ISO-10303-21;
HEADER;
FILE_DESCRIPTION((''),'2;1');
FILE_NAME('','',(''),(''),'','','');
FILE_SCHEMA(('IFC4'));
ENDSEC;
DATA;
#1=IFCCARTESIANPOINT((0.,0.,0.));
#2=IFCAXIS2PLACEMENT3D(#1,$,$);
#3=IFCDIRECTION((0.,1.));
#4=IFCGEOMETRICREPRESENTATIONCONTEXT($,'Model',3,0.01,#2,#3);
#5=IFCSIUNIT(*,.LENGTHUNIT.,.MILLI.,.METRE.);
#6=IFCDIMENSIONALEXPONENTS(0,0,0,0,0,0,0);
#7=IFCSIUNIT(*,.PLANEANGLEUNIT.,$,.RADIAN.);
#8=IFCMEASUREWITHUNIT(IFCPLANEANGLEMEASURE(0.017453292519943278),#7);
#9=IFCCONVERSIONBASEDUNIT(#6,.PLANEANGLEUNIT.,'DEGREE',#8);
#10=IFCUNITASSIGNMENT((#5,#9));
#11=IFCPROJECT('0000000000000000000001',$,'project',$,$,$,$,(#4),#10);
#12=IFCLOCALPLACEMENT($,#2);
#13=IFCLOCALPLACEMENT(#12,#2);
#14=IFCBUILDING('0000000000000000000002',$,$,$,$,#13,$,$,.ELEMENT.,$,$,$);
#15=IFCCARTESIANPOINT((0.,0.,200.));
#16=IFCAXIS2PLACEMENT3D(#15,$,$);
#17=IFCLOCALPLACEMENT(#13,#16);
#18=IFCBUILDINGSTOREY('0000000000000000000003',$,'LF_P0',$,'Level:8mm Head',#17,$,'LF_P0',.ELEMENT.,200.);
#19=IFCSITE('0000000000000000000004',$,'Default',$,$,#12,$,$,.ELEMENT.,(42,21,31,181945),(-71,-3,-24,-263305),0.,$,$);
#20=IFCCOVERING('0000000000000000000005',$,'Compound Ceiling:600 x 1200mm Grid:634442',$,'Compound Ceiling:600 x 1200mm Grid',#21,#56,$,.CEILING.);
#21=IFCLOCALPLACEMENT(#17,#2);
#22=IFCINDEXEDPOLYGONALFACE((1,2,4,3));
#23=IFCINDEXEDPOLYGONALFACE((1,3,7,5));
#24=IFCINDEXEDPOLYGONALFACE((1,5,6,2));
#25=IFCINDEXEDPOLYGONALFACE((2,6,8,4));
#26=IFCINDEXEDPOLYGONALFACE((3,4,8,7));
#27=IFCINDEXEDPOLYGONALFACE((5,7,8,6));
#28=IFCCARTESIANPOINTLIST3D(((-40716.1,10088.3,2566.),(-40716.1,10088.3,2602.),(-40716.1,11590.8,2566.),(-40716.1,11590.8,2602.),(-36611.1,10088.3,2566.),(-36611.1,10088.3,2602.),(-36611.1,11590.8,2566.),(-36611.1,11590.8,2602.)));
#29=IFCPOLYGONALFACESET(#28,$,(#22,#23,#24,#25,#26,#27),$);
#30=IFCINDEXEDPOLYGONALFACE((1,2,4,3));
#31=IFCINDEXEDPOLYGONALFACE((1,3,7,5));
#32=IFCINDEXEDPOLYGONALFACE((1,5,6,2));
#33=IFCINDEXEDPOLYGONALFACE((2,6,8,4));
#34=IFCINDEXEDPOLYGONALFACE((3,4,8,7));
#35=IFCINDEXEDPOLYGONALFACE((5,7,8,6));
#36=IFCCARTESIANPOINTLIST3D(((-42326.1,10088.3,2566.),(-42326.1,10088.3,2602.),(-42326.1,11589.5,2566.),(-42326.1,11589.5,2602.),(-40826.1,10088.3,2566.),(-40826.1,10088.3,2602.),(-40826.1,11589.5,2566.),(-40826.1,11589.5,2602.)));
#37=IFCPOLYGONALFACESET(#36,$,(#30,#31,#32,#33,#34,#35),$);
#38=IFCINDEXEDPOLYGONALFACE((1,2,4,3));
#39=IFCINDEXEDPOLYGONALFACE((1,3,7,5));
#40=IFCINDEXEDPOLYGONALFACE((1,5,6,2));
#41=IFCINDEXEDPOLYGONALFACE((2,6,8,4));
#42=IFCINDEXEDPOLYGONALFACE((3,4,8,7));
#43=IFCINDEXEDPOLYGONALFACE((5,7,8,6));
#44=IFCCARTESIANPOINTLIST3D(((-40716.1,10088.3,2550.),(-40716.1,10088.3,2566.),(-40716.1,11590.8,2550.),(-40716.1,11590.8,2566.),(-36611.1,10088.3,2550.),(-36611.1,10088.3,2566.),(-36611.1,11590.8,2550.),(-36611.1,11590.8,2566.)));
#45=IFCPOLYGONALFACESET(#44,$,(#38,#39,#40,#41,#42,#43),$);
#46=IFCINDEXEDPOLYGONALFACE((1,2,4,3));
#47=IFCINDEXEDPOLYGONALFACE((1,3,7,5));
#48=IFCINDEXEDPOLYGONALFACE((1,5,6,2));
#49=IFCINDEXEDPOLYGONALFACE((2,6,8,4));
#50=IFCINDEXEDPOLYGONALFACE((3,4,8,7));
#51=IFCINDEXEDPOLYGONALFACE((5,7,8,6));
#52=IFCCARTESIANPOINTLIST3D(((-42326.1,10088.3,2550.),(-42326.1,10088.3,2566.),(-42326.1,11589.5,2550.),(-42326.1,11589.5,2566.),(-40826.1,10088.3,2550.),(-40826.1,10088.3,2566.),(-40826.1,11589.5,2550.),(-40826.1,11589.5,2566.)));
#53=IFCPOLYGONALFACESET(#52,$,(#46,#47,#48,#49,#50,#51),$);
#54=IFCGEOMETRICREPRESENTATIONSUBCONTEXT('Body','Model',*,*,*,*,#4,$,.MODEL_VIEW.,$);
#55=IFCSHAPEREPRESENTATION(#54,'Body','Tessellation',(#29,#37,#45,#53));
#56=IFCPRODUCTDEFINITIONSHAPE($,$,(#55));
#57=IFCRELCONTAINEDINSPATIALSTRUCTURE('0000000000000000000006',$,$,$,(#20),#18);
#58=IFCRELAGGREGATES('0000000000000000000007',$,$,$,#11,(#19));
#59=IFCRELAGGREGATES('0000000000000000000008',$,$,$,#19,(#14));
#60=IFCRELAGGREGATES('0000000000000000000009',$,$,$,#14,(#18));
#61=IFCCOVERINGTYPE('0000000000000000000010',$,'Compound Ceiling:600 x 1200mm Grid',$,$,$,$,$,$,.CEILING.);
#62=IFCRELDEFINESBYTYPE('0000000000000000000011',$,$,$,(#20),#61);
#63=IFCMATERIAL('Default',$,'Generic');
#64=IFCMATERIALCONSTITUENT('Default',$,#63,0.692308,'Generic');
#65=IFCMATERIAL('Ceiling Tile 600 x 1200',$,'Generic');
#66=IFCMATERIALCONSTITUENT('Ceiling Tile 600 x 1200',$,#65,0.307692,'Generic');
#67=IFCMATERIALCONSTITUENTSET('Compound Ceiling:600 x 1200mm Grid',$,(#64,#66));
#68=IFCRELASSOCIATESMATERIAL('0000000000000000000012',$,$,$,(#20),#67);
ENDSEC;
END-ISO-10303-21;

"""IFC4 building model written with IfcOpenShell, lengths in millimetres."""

from ifc_helpers import new_model, entity, si_unit, converted_unit, direction, frame, origin, place, context, subcontext, project, spatial, indexed_curve, outline, extrude, material, constituent, constituent_set, type_object, element, save


model = new_model("IFC4")

# Units and contexts
model_context = context("Model", 3, precision=0.01, world=origin(), true_north=direction((0.0, 1.0)))
body_context = subcontext(model_context, "Body", "Model", "MODEL_VIEW")
ifc_project = project(units=[si_unit("LENGTHUNIT", "METRE", prefix="MILLI"), converted_unit("PLANEANGLEUNIT", "DEGREE", entity("IfcPlaneAngleMeasure", 0.017453292519943278), si_unit("PLANEANGLEUNIT", "RADIAN"), dimensions=[0, 0, 0, 0, 0, 0, 0])], contexts=[model_context])

# Site, building, storey
site_placement = place(None, origin())
site = spatial("IfcSite", under=ifc_project, at=site_placement, Name="Default", CompositionType="ELEMENT", RefLatitude=(42, 21, 31, 181945), RefLongitude=(-71, -3, -24, -263305), RefElevation=0.0)
building_placement = place(site_placement, origin())
building = spatial("IfcBuilding", under=site, at=building_placement, CompositionType="ELEMENT")
storey_placement = place(building_placement, frame((0.0, 0.0, 200.0)))
storey = spatial("IfcBuildingStorey", under=building, at=storey_placement, Name="LF_P0", ObjectType="Level:8mm Head", LongName="LF_P0", CompositionType="ELEMENT", Elevation=200.0)

# Covering
ifc_material_1 = material(Name="Default", Category="Generic")
ifc_constituent_1 = constituent(ifc_material_1, Name="Default", Category="Generic", fraction=0.692308)
ifc_material_2 = material(Name="Ceiling Tile 600 x 1200", Category="Generic")
ifc_constituent_2 = constituent(ifc_material_2, Name="Ceiling Tile 600 x 1200", Category="Generic", fraction=0.307692)
ifc_constituent_set = constituent_set(constituents=[ifc_constituent_1, ifc_constituent_2], Name="Compound Ceiling:600 x 1200mm Grid")
covering_type = type_object("IfcCoveringType", Name="Compound Ceiling:600 x 1200mm Grid", PredefinedType="CEILING")
covering_1_placement = place(storey_placement, origin())
element("IfcCovering", 1, at=covering_1_placement, inside=storey, type_object=covering_type, material=ifc_constituent_set, Name="Compound Ceiling:600 x 1200mm Grid:634442", ObjectType="Compound Ceiling:600 x 1200mm Grid", PredefinedType="CEILING", context=body_context, shape_type="SweptSolid", body=[
    extrude(outline(indexed_curve([(-751.3, -2052.5), (751.3, -2052.5), (751.3, 2052.5), (-751.3, 2052.5), (-751.3, -2052.5)], self_intersect=False)), frame((-38663.6, 10839.6, 2566.0), z_axis=(0.0, 0.0, 1.0), x_axis=(0.0, -1.0, 0.0)), (0.0, 0.0, 1.0), 36.0),
    extrude(outline(indexed_curve([(-750.6, -750.0), (750.6, -750.0), (750.6, 750.0), (-750.6, 750.0), (-750.6, -750.0)], self_intersect=False)), frame((-41576.1, 10838.9, 2566.0), z_axis=(0.0, 0.0, 1.0), x_axis=(0.0, 1.0, 0.0)), (0.0, 0.0, 1.0), 36.0),
    extrude(outline(indexed_curve([(-2052.5, -751.3), (2052.5, -751.3), (2052.5, 751.3), (-2052.5, 751.3), (-2052.5, -751.3)], self_intersect=False)), frame((-38663.6, 10839.6, 2550.0), z_axis=(0.0, 0.0, 1.0), x_axis=(-1.0, 0.0, 0.0)), (0.0, 0.0, 1.0), 16.0),
    extrude(outline(indexed_curve([(-750.0, -750.6), (750.0, -750.6), (750.0, 750.6), (-750.0, 750.6), (-750.0, -750.6)], self_intersect=False)), frame((-41576.1, 10838.9, 2550.0)), (0.0, 0.0, 1.0), 16.0),
])

save(model, "model.ifc")
